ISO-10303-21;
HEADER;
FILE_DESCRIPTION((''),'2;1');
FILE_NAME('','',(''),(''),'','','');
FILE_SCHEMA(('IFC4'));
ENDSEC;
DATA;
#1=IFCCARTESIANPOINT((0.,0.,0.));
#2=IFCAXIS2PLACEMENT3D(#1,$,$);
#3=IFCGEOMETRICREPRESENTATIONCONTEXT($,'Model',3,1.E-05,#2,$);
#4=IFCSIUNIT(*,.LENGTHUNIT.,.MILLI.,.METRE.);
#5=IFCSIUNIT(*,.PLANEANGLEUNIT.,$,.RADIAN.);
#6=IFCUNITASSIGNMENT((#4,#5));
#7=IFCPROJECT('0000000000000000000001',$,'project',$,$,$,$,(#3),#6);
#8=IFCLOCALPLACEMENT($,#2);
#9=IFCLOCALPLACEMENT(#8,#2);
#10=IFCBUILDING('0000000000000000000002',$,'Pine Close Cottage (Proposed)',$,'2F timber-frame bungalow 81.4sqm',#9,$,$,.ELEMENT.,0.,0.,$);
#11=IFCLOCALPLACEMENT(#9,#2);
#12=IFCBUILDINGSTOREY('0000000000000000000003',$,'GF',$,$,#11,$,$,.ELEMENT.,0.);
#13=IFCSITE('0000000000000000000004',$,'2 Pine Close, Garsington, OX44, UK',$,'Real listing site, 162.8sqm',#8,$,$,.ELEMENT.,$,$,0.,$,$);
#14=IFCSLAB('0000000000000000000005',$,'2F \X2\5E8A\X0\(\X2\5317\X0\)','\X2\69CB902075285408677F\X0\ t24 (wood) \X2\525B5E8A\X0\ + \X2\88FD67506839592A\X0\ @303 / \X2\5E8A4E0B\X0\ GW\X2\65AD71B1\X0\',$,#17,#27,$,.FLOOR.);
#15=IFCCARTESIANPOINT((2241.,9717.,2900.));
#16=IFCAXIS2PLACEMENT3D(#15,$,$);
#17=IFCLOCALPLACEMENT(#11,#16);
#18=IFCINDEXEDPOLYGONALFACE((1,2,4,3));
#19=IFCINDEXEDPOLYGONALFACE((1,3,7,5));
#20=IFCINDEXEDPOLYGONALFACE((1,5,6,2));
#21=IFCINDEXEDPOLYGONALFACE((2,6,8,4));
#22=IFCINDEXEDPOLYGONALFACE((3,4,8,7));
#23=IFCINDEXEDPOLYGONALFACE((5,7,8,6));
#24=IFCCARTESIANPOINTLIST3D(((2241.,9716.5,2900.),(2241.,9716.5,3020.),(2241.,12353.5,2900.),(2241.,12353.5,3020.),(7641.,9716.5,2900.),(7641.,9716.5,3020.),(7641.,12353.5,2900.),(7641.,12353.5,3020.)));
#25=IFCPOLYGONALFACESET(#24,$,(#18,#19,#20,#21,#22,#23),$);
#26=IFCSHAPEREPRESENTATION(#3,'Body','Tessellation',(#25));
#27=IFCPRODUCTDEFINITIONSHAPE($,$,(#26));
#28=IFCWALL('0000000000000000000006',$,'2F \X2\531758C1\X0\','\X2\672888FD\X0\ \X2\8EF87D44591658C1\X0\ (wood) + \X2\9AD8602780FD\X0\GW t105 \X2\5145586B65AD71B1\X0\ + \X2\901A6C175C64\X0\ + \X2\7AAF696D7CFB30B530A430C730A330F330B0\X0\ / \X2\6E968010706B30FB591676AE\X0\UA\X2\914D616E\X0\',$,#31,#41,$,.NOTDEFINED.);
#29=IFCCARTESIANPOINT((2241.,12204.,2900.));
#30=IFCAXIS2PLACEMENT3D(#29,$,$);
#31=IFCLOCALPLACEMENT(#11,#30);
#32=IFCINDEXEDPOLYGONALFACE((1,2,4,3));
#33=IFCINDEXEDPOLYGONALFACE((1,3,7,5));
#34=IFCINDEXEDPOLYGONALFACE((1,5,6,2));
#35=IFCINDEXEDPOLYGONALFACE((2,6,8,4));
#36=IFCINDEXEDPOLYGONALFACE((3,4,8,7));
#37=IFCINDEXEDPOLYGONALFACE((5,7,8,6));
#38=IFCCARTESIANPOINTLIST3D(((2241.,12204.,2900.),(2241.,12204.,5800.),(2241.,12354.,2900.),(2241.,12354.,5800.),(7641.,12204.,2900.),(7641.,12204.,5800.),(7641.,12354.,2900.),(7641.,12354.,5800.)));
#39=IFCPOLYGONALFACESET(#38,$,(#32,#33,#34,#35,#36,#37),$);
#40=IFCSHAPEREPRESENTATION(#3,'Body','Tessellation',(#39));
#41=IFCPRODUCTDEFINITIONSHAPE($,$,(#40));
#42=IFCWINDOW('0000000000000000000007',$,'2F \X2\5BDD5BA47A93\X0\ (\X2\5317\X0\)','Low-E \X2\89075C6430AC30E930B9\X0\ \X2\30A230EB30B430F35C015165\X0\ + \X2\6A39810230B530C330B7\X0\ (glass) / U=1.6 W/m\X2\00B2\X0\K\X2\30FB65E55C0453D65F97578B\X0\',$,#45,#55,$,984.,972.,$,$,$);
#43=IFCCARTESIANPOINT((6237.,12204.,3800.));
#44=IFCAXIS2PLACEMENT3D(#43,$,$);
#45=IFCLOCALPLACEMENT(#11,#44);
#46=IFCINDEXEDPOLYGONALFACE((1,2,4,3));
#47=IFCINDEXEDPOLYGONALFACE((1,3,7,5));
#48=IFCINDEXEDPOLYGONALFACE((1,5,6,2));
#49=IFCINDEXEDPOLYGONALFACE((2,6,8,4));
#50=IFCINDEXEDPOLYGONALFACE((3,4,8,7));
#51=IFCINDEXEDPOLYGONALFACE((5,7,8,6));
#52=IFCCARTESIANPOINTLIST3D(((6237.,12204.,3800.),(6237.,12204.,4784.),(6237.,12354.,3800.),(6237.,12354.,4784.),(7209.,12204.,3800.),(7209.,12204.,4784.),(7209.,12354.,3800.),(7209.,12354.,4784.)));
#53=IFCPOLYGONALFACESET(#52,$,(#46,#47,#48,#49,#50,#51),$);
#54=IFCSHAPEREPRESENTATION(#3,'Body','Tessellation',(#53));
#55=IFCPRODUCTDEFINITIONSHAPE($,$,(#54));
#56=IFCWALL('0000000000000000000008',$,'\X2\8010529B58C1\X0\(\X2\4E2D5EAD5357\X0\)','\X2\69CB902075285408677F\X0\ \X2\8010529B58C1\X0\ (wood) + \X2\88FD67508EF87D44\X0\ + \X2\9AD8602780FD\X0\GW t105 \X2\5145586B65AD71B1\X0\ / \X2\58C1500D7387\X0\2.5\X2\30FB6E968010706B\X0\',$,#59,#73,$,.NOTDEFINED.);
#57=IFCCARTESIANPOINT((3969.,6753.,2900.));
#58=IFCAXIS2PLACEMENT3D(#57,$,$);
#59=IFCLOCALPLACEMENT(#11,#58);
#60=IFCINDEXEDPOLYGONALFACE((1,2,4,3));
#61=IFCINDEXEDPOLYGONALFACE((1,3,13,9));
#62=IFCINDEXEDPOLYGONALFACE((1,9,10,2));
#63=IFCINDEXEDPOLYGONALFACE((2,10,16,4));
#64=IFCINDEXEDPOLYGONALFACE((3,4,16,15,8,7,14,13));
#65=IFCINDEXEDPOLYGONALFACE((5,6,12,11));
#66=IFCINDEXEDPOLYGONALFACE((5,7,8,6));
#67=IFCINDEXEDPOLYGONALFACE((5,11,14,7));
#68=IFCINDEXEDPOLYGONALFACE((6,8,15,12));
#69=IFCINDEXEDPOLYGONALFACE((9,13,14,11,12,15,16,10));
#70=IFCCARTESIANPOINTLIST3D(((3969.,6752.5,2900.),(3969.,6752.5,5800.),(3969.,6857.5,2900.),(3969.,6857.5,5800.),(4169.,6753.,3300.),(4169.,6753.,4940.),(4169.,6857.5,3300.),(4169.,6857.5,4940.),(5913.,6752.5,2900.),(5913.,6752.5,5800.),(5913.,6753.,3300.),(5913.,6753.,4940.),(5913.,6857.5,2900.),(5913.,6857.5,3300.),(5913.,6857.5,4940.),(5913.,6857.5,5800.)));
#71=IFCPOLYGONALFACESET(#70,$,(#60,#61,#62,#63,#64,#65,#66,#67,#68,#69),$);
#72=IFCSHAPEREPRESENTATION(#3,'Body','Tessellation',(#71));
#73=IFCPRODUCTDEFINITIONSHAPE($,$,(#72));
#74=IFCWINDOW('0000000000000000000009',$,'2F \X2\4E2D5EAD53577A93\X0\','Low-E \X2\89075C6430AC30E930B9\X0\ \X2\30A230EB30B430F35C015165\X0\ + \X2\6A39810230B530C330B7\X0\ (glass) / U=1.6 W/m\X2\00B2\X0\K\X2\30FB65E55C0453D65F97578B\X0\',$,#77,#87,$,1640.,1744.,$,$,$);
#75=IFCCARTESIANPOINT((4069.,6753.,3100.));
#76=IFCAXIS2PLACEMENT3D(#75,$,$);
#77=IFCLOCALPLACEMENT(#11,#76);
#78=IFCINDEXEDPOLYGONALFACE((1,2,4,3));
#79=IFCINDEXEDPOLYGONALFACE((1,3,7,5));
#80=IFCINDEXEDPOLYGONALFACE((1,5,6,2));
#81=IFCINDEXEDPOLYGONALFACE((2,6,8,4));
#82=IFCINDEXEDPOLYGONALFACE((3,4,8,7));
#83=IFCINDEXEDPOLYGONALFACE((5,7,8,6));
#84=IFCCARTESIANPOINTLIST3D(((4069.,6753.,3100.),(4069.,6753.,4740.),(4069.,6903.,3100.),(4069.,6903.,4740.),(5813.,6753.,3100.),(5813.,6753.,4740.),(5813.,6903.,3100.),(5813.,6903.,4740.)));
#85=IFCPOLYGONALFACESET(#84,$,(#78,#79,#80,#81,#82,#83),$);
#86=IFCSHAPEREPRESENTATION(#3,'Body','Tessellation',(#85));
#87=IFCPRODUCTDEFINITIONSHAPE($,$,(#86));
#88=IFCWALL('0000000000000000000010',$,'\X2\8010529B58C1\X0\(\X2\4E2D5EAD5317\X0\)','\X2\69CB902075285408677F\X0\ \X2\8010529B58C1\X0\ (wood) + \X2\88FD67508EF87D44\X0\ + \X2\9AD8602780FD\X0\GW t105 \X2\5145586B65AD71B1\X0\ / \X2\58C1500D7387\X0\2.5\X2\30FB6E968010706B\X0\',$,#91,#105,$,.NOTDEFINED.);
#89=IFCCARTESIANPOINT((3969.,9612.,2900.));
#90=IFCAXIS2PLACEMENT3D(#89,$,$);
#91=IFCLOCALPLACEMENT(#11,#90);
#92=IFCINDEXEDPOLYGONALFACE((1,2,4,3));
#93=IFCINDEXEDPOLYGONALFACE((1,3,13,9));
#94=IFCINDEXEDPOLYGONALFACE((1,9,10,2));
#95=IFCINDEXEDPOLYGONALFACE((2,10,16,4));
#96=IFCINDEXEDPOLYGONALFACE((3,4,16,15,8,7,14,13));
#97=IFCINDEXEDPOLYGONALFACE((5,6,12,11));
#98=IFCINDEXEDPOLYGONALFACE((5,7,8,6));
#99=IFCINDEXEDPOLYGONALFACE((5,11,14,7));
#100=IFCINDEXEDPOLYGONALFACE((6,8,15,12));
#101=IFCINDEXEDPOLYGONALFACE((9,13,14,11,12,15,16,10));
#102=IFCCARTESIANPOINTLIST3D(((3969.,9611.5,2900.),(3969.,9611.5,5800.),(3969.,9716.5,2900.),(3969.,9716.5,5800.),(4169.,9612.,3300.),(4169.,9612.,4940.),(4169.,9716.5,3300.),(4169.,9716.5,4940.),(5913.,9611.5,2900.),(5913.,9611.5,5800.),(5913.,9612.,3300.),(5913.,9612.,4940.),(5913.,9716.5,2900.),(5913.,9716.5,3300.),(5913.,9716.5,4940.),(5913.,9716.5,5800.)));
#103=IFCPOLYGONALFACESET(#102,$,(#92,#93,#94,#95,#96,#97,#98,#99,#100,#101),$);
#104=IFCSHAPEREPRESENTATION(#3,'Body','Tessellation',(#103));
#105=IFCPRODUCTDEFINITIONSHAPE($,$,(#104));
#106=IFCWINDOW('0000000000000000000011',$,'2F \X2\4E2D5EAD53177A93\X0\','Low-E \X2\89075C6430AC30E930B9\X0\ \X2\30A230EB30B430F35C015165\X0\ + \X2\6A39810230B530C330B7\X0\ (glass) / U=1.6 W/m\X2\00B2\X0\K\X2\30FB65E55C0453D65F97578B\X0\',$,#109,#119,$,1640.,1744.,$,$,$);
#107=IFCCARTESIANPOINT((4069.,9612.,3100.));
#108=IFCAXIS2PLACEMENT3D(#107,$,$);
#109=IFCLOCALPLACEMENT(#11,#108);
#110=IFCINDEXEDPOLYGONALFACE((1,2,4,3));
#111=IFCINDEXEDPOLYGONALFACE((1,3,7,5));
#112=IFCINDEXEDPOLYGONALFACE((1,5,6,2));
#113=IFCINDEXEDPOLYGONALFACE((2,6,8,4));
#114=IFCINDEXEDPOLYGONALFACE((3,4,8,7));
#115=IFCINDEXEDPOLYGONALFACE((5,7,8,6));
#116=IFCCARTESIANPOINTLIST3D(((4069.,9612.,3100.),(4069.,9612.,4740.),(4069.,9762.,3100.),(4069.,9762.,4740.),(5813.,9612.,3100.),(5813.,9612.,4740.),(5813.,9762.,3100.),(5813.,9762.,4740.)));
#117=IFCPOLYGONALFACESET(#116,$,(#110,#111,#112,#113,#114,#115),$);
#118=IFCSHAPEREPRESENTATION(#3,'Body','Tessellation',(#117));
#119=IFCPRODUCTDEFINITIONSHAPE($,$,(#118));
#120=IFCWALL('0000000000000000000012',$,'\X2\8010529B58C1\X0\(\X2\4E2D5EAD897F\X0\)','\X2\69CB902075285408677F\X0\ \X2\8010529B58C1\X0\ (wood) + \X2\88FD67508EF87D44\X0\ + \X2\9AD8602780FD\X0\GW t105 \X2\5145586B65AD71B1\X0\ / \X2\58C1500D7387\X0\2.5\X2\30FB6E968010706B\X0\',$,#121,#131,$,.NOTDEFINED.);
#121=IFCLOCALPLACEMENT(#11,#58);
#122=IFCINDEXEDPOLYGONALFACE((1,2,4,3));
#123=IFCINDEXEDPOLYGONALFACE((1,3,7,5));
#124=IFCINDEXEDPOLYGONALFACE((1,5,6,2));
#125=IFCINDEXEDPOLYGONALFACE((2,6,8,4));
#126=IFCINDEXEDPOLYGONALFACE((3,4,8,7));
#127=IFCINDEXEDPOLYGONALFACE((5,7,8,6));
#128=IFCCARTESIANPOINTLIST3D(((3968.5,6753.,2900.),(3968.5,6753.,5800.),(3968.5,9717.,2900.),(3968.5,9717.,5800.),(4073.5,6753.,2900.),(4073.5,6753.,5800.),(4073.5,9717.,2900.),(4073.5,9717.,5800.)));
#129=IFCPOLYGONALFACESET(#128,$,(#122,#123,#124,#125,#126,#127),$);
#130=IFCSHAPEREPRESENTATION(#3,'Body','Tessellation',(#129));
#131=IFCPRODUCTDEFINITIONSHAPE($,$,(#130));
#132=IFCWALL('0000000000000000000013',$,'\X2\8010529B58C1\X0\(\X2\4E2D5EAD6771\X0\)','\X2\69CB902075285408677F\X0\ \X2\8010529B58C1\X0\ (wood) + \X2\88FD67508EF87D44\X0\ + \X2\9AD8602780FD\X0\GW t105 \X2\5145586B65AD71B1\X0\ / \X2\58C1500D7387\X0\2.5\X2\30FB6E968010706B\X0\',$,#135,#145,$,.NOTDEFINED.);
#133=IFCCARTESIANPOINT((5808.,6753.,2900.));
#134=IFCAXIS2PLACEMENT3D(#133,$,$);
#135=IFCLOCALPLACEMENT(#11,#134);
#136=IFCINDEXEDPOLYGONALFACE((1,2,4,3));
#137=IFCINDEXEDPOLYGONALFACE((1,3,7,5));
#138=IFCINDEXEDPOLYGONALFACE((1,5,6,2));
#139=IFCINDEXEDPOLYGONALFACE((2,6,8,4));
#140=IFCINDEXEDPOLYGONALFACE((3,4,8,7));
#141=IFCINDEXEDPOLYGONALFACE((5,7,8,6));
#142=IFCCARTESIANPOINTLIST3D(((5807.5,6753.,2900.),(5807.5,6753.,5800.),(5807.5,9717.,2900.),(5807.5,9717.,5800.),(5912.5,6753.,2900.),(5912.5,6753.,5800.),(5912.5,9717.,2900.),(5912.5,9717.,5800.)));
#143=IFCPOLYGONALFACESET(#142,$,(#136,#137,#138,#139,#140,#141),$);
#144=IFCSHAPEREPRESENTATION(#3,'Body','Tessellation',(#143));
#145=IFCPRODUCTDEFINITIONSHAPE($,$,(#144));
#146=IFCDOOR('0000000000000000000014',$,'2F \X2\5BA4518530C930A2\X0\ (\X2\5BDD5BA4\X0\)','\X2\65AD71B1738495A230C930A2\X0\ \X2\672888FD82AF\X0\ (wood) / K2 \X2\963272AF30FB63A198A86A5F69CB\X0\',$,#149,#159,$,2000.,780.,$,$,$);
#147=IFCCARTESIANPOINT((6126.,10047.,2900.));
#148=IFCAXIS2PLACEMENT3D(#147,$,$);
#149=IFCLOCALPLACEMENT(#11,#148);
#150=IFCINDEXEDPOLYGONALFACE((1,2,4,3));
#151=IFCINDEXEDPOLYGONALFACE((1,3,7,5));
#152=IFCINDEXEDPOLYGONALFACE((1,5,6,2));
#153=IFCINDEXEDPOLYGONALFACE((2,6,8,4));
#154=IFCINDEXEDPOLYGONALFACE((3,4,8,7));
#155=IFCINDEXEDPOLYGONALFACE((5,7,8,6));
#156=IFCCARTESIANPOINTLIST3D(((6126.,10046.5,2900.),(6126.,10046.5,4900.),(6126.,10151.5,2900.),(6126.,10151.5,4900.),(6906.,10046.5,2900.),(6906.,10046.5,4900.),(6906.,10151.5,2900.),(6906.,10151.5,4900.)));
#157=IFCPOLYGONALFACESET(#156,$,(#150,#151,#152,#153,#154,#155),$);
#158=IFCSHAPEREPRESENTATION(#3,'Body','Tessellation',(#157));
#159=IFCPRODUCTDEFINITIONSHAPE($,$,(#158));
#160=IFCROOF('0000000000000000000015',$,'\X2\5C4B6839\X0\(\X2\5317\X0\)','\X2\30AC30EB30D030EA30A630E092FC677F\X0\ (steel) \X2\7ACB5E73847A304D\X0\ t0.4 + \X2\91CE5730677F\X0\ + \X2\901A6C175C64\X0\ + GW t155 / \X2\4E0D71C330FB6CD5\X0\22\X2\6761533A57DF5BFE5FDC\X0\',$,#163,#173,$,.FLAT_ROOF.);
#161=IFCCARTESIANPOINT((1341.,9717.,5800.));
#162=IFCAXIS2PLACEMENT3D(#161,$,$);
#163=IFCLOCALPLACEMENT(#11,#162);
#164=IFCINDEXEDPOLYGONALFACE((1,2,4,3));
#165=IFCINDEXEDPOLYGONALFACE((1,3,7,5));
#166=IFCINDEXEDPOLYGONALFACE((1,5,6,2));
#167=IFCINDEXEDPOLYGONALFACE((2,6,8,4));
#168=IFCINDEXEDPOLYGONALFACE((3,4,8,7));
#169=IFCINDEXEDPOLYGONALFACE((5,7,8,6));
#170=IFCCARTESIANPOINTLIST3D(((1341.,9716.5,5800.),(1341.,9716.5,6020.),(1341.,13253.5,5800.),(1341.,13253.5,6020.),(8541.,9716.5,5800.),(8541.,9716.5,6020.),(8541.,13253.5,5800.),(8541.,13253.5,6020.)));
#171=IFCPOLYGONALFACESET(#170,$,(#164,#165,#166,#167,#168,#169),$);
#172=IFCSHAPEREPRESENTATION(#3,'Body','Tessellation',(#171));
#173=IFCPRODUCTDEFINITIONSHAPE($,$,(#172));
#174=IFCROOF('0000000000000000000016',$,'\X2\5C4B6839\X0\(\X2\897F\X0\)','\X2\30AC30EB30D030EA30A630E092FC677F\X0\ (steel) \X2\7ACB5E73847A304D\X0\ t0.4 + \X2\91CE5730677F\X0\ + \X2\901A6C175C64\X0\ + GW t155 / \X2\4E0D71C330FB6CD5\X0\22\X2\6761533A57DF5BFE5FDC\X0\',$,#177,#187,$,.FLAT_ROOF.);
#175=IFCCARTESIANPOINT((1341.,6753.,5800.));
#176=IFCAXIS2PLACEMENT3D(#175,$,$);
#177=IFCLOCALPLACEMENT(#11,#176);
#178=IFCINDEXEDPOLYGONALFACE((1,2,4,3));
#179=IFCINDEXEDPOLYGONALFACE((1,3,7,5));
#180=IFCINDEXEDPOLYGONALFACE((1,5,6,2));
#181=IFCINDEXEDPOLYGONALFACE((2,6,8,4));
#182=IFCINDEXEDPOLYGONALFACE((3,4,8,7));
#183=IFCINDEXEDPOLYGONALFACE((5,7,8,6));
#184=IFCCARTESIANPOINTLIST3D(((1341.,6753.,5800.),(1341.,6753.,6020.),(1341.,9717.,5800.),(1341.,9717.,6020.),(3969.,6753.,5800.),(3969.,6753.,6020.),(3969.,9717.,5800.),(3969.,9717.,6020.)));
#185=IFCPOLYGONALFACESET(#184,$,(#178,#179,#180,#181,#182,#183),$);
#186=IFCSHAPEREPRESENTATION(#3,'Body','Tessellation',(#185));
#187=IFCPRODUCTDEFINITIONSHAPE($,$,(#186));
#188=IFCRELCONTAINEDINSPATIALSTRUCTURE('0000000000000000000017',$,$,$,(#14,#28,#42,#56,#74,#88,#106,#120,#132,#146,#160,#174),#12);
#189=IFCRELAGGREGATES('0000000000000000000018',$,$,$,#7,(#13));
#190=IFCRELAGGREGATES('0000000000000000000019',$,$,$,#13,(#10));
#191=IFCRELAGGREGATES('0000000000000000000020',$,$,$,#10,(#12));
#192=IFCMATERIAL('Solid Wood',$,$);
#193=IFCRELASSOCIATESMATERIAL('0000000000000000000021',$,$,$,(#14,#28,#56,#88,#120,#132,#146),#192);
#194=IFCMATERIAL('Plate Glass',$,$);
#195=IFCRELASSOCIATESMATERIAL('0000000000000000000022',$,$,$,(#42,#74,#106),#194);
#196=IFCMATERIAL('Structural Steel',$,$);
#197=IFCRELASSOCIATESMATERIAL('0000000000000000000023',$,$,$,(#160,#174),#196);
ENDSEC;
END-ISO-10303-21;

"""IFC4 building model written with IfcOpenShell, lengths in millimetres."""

from ifc_helpers import new_model, si_unit, frame, frame_2d, origin, place, context, project, spatial, rectangle, extrude, material, element, fill, save


model = new_model("IFC4")

# Units and contexts
model_context = context("Model", 3, precision=1e-05, world=origin())
ifc_project = project(units=[si_unit("LENGTHUNIT", "METRE", prefix="MILLI"), si_unit("PLANEANGLEUNIT", "RADIAN")], contexts=[model_context])

# Site, building, storey
site_placement = place(None, origin())
site = spatial("IfcSite", under=ifc_project, at=site_placement, Name="2 Pine Close, Garsington, OX44, UK", ObjectType="Real listing site, 162.8sqm", CompositionType="ELEMENT", RefElevation=0.0)
building_placement = place(site_placement, origin())
building = spatial("IfcBuilding", under=site, at=building_placement, Name="Pine Close Cottage (Proposed)", ObjectType="2F timber-frame bungalow 81.4sqm", CompositionType="ELEMENT", ElevationOfRefHeight=0.0, ElevationOfTerrain=0.0)
storey_placement = place(building_placement, origin())
storey = spatial("IfcBuildingStorey", under=building, at=storey_placement, Name="GF", CompositionType="ELEMENT", Elevation=0.0)

# Slab
ifc_material_1 = material(Name="Solid Wood")
slab_placement = place(storey_placement, frame((2241.0, 9717.0, 2900.0)))
element("IfcSlab", 1, at=slab_placement, inside=storey, material=ifc_material_1, Name="2F 床(北)", Description="構造用合板 t24 (wood) 剛床 + 製材根太 @303 / 床下 GW断熱", PredefinedType="FLOOR", context=model_context, shape_type="SweptSolid", body=[
    extrude(rectangle(XDim=5400.0, YDim=2637.0, at=frame_2d((2700.0, 1318.0))), frame((2241.0, 9717.0, 2900.0)), (0.0, 0.0, 1.0), 120.0),
])

# Walls, openings, windows
wall_1_placement = place(storey_placement, frame((2241.0, 12204.0, 2900.0)))
wall_1 = element("IfcWall", 2, at=wall_1_placement, inside=storey, material=ifc_material_1, Name="2F 北壁", Description="木製 軸組外壁 (wood) + 高性能GW t105 充填断熱 + 通気層 + 窯業系サイディング / 準耐火・外皮UA配慮", PredefinedType="NOTDEFINED", context=model_context, shape_type="SweptSolid", body=[
    extrude(rectangle(XDim=5400.0, YDim=150.0, at=frame_2d((2700.0, 75.0))), frame((2241.0, 12204.0, 2900.0)), (0.0, 0.0, 1.0), 2900.0),
])
opening_1_placement = place(storey_placement, frame((6237.0, 12204.0, 3800.0)))
opening_1 = element("IfcOpeningElement", 3, at=opening_1_placement, cuts=wall_1, PredefinedType="NOTDEFINED", context=model_context, shape_type="SweptSolid", body=[
    extrude(rectangle(XDim=972.0, YDim=150.0, at=frame_2d((486.0, 75.0))), frame((6237.0, 12204.0, 3800.0)), (0.0, 0.0, 1.0), 984.0),
])
ifc_material_2 = material(Name="Plate Glass")
window_1_placement = place(storey_placement, frame((6237.0, 12204.0, 3800.0)))
window_1 = element("IfcWindow", 4, at=window_1_placement, inside=storey, material=ifc_material_2, Name="2F 寝室窓 (北)", Description="Low-E 複層ガラス アルゴン封入 + 樹脂サッシ (glass) / U=1.6 W/m²K・日射取得型", OverallHeight=984.0, OverallWidth=972.0, context=model_context, shape_type="SweptSolid", body=[
    extrude(rectangle(XDim=972.0, YDim=150.0, at=frame_2d((486.0, 75.0))), frame((6237.0, 12204.0, 3800.0)), (0.0, 0.0, 1.0), 984.0),
])
fill(opening_1, window_1)
wall_2_placement = place(storey_placement, frame((3969.0, 6753.0, 2900.0)))
wall_2 = element("IfcWall", 5, at=wall_2_placement, inside=storey, material=ifc_material_1, Name="耐力壁(中庭南)", Description="構造用合板 耐力壁 (wood) + 製材軸組 + 高性能GW t105 充填断熱 / 壁倍率2.5・準耐火", PredefinedType="NOTDEFINED", context=model_context, shape_type="SweptSolid", body=[
    extrude(rectangle(XDim=1944.0, YDim=105.0, at=frame_2d((972.0, 52.0))), frame((3969.0, 6753.0, 2900.0)), (0.0, 0.0, 1.0), 2900.0),
])
opening_2_placement = place(storey_placement, frame((4069.0, 6753.0, 3100.0)))
opening_2 = element("IfcOpeningElement", 6, at=opening_2_placement, cuts=wall_2, PredefinedType="NOTDEFINED", context=model_context, shape_type="SweptSolid", body=[
    extrude(rectangle(XDim=1744.0, YDim=150.0, at=frame_2d((872.0, 75.0))), frame((4069.0, 6753.0, 3100.0)), (0.0, 0.0, 1.0), 1640.0),
])
window_2_placement = place(storey_placement, frame((4069.0, 6753.0, 3100.0)))
window_2 = element("IfcWindow", 7, at=window_2_placement, inside=storey, material=ifc_material_2, Name="2F 中庭南窓", Description="Low-E 複層ガラス アルゴン封入 + 樹脂サッシ (glass) / U=1.6 W/m²K・日射取得型", OverallHeight=1640.0, OverallWidth=1744.0, context=model_context, shape_type="SweptSolid", body=[
    extrude(rectangle(XDim=1744.0, YDim=150.0, at=frame_2d((872.0, 75.0))), frame((4069.0, 6753.0, 3100.0)), (0.0, 0.0, 1.0), 1640.0),
])
fill(opening_2, window_2)
wall_3_placement = place(storey_placement, frame((3969.0, 9612.0, 2900.0)))
wall_3 = element("IfcWall", 8, at=wall_3_placement, inside=storey, material=ifc_material_1, Name="耐力壁(中庭北)", Description="構造用合板 耐力壁 (wood) + 製材軸組 + 高性能GW t105 充填断熱 / 壁倍率2.5・準耐火", PredefinedType="NOTDEFINED", context=model_context, shape_type="SweptSolid", body=[
    extrude(rectangle(XDim=1944.0, YDim=105.0, at=frame_2d((972.0, 52.0))), frame((3969.0, 9612.0, 2900.0)), (0.0, 0.0, 1.0), 2900.0),
])
opening_3_placement = place(storey_placement, frame((4069.0, 9612.0, 3100.0)))
opening_3 = element("IfcOpeningElement", 9, at=opening_3_placement, cuts=wall_3, PredefinedType="NOTDEFINED", context=model_context, shape_type="SweptSolid", body=[
    extrude(rectangle(XDim=1744.0, YDim=150.0, at=frame_2d((872.0, 75.0))), frame((4069.0, 9612.0, 3100.0)), (0.0, 0.0, 1.0), 1640.0),
])
window_3_placement = place(storey_placement, frame((4069.0, 9612.0, 3100.0)))
window_3 = element("IfcWindow", 10, at=window_3_placement, inside=storey, material=ifc_material_2, Name="2F 中庭北窓", Description="Low-E 複層ガラス アルゴン封入 + 樹脂サッシ (glass) / U=1.6 W/m²K・日射取得型", OverallHeight=1640.0, OverallWidth=1744.0, context=model_context, shape_type="SweptSolid", body=[
    extrude(rectangle(XDim=1744.0, YDim=150.0, at=frame_2d((872.0, 75.0))), frame((4069.0, 9612.0, 3100.0)), (0.0, 0.0, 1.0), 1640.0),
])
fill(opening_3, window_3)

# Walls
wall_4_placement = place(storey_placement, frame((3969.0, 6753.0, 2900.0)))
element("IfcWall", 11, at=wall_4_placement, inside=storey, material=ifc_material_1, Name="耐力壁(中庭西)", Description="構造用合板 耐力壁 (wood) + 製材軸組 + 高性能GW t105 充填断熱 / 壁倍率2.5・準耐火", PredefinedType="NOTDEFINED", context=model_context, shape_type="SweptSolid", body=[
    extrude(rectangle(XDim=105.0, YDim=2964.0, at=frame_2d((52.0, 1482.0))), frame((3969.0, 6753.0, 2900.0)), (0.0, 0.0, 1.0), 2900.0),
])
wall_5_placement = place(storey_placement, frame((5808.0, 6753.0, 2900.0)))
element("IfcWall", 12, at=wall_5_placement, inside=storey, material=ifc_material_1, Name="耐力壁(中庭東)", Description="構造用合板 耐力壁 (wood) + 製材軸組 + 高性能GW t105 充填断熱 / 壁倍率2.5・準耐火", PredefinedType="NOTDEFINED", context=model_context, shape_type="SweptSolid", body=[
    extrude(rectangle(XDim=105.0, YDim=2964.0, at=frame_2d((52.0, 1482.0))), frame((5808.0, 6753.0, 2900.0)), (0.0, 0.0, 1.0), 2900.0),
])

# Door
door_placement = place(storey_placement, frame((6126.0, 10047.0, 2900.0)))
element("IfcDoor", 13, at=door_placement, inside=storey, material=ifc_material_1, Name="2F 室内ドア (寝室)", Description="断熱玄関ドア 木製芯 (wood) / K2 防犯・採風機構", OverallHeight=2000.0, OverallWidth=780.0, context=model_context, shape_type="SweptSolid", body=[
    extrude(rectangle(XDim=780.0, YDim=105.0, at=frame_2d((390.0, 52.0))), frame((6126.0, 10047.0, 2900.0)), (0.0, 0.0, 1.0), 2000.0),
])

# Roofs
ifc_material_3 = material(Name="Structural Steel")
for number, where, name in (
    (14, (1341.0, 9717.0, 5800.0), "屋根(北)"),
):
    element("IfcRoof", number, at=place(storey_placement, frame(where)), inside=storey, material=ifc_material_3, Name=name, Description="ガルバリウム鋼板 (steel) 立平葺き t0.4 + 野地板 + 通気層 + GW t155 / 不燃・法22条区域対応", PredefinedType="FLAT_ROOF", context=model_context, shape_type="SweptSolid", body=[
        extrude(rectangle(XDim=7200.0, YDim=3537.0, at=frame_2d((3600.0, 1768.0))), frame((1341.0, 9717.0, 5800.0)), (0.0, 0.0, 1.0), 220.0),
    ])
roof_1_placement = place(storey_placement, frame((1341.0, 6753.0, 5800.0)))
element("IfcRoof", 15, at=roof_1_placement, inside=storey, material=ifc_material_3, Name="屋根(西)", Description="ガルバリウム鋼板 (steel) 立平葺き t0.4 + 野地板 + 通気層 + GW t155 / 不燃・法22条区域対応", PredefinedType="FLAT_ROOF", context=model_context, shape_type="SweptSolid", body=[
    extrude(rectangle(XDim=2628.0, YDim=2964.0, at=frame_2d((1314.0, 1482.0))), frame((1341.0, 6753.0, 5800.0)), (0.0, 0.0, 1.0), 220.0),
])

save(model, "model.ifc")
